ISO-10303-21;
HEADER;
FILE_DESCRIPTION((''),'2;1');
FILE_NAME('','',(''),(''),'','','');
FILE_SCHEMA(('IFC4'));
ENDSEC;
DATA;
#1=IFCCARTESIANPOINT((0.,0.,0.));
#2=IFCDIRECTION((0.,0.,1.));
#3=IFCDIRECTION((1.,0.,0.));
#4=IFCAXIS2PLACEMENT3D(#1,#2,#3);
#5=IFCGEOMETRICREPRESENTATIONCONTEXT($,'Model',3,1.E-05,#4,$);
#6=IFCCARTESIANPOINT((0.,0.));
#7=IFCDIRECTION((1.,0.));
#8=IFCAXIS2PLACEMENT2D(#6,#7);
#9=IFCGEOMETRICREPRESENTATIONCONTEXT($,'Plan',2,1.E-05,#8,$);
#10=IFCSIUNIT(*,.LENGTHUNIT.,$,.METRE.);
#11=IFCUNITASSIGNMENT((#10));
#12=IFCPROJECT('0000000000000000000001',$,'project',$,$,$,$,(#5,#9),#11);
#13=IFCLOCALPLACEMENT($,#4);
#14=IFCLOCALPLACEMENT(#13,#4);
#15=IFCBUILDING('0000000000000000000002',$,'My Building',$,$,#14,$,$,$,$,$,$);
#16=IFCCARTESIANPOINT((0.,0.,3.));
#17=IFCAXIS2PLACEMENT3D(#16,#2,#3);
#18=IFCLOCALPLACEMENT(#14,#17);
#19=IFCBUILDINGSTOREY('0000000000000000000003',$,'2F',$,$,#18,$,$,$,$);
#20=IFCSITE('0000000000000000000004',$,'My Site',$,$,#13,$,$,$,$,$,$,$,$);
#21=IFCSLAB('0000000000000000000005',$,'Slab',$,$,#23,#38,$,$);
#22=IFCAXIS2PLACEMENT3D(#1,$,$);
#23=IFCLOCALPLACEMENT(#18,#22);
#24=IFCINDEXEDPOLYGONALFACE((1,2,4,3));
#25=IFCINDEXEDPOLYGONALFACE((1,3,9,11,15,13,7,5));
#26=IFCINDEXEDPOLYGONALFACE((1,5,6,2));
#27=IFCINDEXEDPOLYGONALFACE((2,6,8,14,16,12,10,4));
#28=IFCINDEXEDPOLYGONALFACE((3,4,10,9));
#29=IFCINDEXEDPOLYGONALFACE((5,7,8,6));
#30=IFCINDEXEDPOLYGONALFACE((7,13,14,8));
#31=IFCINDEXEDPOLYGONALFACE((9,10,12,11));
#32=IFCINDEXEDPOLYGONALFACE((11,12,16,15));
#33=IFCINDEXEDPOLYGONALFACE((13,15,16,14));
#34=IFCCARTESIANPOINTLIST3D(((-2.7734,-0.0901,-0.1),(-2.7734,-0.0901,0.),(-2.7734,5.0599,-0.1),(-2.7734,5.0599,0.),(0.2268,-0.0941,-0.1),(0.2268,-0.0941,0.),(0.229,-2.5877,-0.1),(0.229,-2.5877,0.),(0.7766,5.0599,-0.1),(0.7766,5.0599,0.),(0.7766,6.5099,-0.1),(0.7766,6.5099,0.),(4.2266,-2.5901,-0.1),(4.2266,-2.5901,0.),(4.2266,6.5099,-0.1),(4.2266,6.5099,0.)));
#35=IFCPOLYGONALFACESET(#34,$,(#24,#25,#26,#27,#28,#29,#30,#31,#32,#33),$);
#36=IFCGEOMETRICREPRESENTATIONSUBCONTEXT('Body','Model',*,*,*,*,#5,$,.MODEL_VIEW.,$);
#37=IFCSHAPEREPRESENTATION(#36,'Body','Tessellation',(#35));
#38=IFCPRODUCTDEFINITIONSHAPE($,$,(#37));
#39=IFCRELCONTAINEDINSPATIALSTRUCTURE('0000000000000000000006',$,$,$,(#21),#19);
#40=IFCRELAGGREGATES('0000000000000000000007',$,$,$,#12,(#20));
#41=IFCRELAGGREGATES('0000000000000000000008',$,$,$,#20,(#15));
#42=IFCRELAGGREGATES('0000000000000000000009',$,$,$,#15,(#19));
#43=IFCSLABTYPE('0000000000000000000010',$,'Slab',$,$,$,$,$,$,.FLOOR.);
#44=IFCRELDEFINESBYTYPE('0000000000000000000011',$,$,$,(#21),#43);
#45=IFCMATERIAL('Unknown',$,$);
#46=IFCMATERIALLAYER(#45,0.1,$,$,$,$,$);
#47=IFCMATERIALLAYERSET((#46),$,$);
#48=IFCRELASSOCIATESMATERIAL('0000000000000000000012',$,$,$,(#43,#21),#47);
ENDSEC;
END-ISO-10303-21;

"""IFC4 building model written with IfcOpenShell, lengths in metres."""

from ifc_helpers import new_model, si_unit, frame, origin_with_axes, origin_2d_with_axis, place, context, subcontext, project, spatial, indexed_curve, outline, extrude, material, layer, layer_set, layer_usage, type_object, element, save


model = new_model("IFC4")

# Units and contexts
model_context = context("Model", 3, precision=1e-05, world=origin_with_axes())
plan_context = context("Plan", 2, precision=1e-05, world=origin_2d_with_axis())
body_context = subcontext(model_context, "Body", "Model", "MODEL_VIEW")
ifc_project = project(units=[si_unit("LENGTHUNIT", "METRE")], contexts=[model_context, plan_context])

# Site, building, storey
site_placement = place(None, origin_with_axes())
site = spatial("IfcSite", under=ifc_project, at=site_placement, Name="My Site")
building_placement = place(site_placement, origin_with_axes())
building = spatial("IfcBuilding", under=site, at=building_placement, Name="My Building")
storey_placement = place(building_placement, frame((0.0, 0.0, 3.0), z_axis=(0.0, 0.0, 1.0), x_axis=(1.0, 0.0, 0.0)))
storey = spatial("IfcBuildingStorey", under=building, at=storey_placement, Name="2F")

# Slab
ifc_material = material(Name="Unknown")
ifc_layer = layer(ifc_material, 0.1)
ifc_layer_set = layer_set([ifc_layer])
ifc_layer_usage = layer_usage(ifc_layer_set, "AXIS3", "POSITIVE", -0.1)
slab_type = type_object("IfcSlabType", Name="Slab", PredefinedType="FLOOR", material=ifc_layer_set)
slab_placement = place(storey_placement, frame((0.229, -2.5877, 0.0), z_axis=(0.0, 0.0, 1.0), x_axis=(1.0, 0.0, 0.0)))
element("IfcSlab", 1, at=slab_placement, inside=storey, type_object=slab_type, material=ifc_layer_usage, Name="Slab", context=body_context, shape_type="SweptSolid", body=[
    extrude(outline(indexed_curve([(0.0, 0.0), (-0.0023, 2.4936), (-3.0024, 2.4976), (-3.0024, 7.6476), (0.5476, 7.6476), (0.5476, 9.0976), (3.9976, 9.0976), (3.9976, -0.0024), (0.0, 0.0)])), frame((0.0, 0.0, -0.1), z_axis=(0.0, 0.0, 1.0), x_axis=(1.0, 0.0, 0.0)), (0.0, 0.0, 1.0), 0.1),
])

save(model, "model.ifc")
